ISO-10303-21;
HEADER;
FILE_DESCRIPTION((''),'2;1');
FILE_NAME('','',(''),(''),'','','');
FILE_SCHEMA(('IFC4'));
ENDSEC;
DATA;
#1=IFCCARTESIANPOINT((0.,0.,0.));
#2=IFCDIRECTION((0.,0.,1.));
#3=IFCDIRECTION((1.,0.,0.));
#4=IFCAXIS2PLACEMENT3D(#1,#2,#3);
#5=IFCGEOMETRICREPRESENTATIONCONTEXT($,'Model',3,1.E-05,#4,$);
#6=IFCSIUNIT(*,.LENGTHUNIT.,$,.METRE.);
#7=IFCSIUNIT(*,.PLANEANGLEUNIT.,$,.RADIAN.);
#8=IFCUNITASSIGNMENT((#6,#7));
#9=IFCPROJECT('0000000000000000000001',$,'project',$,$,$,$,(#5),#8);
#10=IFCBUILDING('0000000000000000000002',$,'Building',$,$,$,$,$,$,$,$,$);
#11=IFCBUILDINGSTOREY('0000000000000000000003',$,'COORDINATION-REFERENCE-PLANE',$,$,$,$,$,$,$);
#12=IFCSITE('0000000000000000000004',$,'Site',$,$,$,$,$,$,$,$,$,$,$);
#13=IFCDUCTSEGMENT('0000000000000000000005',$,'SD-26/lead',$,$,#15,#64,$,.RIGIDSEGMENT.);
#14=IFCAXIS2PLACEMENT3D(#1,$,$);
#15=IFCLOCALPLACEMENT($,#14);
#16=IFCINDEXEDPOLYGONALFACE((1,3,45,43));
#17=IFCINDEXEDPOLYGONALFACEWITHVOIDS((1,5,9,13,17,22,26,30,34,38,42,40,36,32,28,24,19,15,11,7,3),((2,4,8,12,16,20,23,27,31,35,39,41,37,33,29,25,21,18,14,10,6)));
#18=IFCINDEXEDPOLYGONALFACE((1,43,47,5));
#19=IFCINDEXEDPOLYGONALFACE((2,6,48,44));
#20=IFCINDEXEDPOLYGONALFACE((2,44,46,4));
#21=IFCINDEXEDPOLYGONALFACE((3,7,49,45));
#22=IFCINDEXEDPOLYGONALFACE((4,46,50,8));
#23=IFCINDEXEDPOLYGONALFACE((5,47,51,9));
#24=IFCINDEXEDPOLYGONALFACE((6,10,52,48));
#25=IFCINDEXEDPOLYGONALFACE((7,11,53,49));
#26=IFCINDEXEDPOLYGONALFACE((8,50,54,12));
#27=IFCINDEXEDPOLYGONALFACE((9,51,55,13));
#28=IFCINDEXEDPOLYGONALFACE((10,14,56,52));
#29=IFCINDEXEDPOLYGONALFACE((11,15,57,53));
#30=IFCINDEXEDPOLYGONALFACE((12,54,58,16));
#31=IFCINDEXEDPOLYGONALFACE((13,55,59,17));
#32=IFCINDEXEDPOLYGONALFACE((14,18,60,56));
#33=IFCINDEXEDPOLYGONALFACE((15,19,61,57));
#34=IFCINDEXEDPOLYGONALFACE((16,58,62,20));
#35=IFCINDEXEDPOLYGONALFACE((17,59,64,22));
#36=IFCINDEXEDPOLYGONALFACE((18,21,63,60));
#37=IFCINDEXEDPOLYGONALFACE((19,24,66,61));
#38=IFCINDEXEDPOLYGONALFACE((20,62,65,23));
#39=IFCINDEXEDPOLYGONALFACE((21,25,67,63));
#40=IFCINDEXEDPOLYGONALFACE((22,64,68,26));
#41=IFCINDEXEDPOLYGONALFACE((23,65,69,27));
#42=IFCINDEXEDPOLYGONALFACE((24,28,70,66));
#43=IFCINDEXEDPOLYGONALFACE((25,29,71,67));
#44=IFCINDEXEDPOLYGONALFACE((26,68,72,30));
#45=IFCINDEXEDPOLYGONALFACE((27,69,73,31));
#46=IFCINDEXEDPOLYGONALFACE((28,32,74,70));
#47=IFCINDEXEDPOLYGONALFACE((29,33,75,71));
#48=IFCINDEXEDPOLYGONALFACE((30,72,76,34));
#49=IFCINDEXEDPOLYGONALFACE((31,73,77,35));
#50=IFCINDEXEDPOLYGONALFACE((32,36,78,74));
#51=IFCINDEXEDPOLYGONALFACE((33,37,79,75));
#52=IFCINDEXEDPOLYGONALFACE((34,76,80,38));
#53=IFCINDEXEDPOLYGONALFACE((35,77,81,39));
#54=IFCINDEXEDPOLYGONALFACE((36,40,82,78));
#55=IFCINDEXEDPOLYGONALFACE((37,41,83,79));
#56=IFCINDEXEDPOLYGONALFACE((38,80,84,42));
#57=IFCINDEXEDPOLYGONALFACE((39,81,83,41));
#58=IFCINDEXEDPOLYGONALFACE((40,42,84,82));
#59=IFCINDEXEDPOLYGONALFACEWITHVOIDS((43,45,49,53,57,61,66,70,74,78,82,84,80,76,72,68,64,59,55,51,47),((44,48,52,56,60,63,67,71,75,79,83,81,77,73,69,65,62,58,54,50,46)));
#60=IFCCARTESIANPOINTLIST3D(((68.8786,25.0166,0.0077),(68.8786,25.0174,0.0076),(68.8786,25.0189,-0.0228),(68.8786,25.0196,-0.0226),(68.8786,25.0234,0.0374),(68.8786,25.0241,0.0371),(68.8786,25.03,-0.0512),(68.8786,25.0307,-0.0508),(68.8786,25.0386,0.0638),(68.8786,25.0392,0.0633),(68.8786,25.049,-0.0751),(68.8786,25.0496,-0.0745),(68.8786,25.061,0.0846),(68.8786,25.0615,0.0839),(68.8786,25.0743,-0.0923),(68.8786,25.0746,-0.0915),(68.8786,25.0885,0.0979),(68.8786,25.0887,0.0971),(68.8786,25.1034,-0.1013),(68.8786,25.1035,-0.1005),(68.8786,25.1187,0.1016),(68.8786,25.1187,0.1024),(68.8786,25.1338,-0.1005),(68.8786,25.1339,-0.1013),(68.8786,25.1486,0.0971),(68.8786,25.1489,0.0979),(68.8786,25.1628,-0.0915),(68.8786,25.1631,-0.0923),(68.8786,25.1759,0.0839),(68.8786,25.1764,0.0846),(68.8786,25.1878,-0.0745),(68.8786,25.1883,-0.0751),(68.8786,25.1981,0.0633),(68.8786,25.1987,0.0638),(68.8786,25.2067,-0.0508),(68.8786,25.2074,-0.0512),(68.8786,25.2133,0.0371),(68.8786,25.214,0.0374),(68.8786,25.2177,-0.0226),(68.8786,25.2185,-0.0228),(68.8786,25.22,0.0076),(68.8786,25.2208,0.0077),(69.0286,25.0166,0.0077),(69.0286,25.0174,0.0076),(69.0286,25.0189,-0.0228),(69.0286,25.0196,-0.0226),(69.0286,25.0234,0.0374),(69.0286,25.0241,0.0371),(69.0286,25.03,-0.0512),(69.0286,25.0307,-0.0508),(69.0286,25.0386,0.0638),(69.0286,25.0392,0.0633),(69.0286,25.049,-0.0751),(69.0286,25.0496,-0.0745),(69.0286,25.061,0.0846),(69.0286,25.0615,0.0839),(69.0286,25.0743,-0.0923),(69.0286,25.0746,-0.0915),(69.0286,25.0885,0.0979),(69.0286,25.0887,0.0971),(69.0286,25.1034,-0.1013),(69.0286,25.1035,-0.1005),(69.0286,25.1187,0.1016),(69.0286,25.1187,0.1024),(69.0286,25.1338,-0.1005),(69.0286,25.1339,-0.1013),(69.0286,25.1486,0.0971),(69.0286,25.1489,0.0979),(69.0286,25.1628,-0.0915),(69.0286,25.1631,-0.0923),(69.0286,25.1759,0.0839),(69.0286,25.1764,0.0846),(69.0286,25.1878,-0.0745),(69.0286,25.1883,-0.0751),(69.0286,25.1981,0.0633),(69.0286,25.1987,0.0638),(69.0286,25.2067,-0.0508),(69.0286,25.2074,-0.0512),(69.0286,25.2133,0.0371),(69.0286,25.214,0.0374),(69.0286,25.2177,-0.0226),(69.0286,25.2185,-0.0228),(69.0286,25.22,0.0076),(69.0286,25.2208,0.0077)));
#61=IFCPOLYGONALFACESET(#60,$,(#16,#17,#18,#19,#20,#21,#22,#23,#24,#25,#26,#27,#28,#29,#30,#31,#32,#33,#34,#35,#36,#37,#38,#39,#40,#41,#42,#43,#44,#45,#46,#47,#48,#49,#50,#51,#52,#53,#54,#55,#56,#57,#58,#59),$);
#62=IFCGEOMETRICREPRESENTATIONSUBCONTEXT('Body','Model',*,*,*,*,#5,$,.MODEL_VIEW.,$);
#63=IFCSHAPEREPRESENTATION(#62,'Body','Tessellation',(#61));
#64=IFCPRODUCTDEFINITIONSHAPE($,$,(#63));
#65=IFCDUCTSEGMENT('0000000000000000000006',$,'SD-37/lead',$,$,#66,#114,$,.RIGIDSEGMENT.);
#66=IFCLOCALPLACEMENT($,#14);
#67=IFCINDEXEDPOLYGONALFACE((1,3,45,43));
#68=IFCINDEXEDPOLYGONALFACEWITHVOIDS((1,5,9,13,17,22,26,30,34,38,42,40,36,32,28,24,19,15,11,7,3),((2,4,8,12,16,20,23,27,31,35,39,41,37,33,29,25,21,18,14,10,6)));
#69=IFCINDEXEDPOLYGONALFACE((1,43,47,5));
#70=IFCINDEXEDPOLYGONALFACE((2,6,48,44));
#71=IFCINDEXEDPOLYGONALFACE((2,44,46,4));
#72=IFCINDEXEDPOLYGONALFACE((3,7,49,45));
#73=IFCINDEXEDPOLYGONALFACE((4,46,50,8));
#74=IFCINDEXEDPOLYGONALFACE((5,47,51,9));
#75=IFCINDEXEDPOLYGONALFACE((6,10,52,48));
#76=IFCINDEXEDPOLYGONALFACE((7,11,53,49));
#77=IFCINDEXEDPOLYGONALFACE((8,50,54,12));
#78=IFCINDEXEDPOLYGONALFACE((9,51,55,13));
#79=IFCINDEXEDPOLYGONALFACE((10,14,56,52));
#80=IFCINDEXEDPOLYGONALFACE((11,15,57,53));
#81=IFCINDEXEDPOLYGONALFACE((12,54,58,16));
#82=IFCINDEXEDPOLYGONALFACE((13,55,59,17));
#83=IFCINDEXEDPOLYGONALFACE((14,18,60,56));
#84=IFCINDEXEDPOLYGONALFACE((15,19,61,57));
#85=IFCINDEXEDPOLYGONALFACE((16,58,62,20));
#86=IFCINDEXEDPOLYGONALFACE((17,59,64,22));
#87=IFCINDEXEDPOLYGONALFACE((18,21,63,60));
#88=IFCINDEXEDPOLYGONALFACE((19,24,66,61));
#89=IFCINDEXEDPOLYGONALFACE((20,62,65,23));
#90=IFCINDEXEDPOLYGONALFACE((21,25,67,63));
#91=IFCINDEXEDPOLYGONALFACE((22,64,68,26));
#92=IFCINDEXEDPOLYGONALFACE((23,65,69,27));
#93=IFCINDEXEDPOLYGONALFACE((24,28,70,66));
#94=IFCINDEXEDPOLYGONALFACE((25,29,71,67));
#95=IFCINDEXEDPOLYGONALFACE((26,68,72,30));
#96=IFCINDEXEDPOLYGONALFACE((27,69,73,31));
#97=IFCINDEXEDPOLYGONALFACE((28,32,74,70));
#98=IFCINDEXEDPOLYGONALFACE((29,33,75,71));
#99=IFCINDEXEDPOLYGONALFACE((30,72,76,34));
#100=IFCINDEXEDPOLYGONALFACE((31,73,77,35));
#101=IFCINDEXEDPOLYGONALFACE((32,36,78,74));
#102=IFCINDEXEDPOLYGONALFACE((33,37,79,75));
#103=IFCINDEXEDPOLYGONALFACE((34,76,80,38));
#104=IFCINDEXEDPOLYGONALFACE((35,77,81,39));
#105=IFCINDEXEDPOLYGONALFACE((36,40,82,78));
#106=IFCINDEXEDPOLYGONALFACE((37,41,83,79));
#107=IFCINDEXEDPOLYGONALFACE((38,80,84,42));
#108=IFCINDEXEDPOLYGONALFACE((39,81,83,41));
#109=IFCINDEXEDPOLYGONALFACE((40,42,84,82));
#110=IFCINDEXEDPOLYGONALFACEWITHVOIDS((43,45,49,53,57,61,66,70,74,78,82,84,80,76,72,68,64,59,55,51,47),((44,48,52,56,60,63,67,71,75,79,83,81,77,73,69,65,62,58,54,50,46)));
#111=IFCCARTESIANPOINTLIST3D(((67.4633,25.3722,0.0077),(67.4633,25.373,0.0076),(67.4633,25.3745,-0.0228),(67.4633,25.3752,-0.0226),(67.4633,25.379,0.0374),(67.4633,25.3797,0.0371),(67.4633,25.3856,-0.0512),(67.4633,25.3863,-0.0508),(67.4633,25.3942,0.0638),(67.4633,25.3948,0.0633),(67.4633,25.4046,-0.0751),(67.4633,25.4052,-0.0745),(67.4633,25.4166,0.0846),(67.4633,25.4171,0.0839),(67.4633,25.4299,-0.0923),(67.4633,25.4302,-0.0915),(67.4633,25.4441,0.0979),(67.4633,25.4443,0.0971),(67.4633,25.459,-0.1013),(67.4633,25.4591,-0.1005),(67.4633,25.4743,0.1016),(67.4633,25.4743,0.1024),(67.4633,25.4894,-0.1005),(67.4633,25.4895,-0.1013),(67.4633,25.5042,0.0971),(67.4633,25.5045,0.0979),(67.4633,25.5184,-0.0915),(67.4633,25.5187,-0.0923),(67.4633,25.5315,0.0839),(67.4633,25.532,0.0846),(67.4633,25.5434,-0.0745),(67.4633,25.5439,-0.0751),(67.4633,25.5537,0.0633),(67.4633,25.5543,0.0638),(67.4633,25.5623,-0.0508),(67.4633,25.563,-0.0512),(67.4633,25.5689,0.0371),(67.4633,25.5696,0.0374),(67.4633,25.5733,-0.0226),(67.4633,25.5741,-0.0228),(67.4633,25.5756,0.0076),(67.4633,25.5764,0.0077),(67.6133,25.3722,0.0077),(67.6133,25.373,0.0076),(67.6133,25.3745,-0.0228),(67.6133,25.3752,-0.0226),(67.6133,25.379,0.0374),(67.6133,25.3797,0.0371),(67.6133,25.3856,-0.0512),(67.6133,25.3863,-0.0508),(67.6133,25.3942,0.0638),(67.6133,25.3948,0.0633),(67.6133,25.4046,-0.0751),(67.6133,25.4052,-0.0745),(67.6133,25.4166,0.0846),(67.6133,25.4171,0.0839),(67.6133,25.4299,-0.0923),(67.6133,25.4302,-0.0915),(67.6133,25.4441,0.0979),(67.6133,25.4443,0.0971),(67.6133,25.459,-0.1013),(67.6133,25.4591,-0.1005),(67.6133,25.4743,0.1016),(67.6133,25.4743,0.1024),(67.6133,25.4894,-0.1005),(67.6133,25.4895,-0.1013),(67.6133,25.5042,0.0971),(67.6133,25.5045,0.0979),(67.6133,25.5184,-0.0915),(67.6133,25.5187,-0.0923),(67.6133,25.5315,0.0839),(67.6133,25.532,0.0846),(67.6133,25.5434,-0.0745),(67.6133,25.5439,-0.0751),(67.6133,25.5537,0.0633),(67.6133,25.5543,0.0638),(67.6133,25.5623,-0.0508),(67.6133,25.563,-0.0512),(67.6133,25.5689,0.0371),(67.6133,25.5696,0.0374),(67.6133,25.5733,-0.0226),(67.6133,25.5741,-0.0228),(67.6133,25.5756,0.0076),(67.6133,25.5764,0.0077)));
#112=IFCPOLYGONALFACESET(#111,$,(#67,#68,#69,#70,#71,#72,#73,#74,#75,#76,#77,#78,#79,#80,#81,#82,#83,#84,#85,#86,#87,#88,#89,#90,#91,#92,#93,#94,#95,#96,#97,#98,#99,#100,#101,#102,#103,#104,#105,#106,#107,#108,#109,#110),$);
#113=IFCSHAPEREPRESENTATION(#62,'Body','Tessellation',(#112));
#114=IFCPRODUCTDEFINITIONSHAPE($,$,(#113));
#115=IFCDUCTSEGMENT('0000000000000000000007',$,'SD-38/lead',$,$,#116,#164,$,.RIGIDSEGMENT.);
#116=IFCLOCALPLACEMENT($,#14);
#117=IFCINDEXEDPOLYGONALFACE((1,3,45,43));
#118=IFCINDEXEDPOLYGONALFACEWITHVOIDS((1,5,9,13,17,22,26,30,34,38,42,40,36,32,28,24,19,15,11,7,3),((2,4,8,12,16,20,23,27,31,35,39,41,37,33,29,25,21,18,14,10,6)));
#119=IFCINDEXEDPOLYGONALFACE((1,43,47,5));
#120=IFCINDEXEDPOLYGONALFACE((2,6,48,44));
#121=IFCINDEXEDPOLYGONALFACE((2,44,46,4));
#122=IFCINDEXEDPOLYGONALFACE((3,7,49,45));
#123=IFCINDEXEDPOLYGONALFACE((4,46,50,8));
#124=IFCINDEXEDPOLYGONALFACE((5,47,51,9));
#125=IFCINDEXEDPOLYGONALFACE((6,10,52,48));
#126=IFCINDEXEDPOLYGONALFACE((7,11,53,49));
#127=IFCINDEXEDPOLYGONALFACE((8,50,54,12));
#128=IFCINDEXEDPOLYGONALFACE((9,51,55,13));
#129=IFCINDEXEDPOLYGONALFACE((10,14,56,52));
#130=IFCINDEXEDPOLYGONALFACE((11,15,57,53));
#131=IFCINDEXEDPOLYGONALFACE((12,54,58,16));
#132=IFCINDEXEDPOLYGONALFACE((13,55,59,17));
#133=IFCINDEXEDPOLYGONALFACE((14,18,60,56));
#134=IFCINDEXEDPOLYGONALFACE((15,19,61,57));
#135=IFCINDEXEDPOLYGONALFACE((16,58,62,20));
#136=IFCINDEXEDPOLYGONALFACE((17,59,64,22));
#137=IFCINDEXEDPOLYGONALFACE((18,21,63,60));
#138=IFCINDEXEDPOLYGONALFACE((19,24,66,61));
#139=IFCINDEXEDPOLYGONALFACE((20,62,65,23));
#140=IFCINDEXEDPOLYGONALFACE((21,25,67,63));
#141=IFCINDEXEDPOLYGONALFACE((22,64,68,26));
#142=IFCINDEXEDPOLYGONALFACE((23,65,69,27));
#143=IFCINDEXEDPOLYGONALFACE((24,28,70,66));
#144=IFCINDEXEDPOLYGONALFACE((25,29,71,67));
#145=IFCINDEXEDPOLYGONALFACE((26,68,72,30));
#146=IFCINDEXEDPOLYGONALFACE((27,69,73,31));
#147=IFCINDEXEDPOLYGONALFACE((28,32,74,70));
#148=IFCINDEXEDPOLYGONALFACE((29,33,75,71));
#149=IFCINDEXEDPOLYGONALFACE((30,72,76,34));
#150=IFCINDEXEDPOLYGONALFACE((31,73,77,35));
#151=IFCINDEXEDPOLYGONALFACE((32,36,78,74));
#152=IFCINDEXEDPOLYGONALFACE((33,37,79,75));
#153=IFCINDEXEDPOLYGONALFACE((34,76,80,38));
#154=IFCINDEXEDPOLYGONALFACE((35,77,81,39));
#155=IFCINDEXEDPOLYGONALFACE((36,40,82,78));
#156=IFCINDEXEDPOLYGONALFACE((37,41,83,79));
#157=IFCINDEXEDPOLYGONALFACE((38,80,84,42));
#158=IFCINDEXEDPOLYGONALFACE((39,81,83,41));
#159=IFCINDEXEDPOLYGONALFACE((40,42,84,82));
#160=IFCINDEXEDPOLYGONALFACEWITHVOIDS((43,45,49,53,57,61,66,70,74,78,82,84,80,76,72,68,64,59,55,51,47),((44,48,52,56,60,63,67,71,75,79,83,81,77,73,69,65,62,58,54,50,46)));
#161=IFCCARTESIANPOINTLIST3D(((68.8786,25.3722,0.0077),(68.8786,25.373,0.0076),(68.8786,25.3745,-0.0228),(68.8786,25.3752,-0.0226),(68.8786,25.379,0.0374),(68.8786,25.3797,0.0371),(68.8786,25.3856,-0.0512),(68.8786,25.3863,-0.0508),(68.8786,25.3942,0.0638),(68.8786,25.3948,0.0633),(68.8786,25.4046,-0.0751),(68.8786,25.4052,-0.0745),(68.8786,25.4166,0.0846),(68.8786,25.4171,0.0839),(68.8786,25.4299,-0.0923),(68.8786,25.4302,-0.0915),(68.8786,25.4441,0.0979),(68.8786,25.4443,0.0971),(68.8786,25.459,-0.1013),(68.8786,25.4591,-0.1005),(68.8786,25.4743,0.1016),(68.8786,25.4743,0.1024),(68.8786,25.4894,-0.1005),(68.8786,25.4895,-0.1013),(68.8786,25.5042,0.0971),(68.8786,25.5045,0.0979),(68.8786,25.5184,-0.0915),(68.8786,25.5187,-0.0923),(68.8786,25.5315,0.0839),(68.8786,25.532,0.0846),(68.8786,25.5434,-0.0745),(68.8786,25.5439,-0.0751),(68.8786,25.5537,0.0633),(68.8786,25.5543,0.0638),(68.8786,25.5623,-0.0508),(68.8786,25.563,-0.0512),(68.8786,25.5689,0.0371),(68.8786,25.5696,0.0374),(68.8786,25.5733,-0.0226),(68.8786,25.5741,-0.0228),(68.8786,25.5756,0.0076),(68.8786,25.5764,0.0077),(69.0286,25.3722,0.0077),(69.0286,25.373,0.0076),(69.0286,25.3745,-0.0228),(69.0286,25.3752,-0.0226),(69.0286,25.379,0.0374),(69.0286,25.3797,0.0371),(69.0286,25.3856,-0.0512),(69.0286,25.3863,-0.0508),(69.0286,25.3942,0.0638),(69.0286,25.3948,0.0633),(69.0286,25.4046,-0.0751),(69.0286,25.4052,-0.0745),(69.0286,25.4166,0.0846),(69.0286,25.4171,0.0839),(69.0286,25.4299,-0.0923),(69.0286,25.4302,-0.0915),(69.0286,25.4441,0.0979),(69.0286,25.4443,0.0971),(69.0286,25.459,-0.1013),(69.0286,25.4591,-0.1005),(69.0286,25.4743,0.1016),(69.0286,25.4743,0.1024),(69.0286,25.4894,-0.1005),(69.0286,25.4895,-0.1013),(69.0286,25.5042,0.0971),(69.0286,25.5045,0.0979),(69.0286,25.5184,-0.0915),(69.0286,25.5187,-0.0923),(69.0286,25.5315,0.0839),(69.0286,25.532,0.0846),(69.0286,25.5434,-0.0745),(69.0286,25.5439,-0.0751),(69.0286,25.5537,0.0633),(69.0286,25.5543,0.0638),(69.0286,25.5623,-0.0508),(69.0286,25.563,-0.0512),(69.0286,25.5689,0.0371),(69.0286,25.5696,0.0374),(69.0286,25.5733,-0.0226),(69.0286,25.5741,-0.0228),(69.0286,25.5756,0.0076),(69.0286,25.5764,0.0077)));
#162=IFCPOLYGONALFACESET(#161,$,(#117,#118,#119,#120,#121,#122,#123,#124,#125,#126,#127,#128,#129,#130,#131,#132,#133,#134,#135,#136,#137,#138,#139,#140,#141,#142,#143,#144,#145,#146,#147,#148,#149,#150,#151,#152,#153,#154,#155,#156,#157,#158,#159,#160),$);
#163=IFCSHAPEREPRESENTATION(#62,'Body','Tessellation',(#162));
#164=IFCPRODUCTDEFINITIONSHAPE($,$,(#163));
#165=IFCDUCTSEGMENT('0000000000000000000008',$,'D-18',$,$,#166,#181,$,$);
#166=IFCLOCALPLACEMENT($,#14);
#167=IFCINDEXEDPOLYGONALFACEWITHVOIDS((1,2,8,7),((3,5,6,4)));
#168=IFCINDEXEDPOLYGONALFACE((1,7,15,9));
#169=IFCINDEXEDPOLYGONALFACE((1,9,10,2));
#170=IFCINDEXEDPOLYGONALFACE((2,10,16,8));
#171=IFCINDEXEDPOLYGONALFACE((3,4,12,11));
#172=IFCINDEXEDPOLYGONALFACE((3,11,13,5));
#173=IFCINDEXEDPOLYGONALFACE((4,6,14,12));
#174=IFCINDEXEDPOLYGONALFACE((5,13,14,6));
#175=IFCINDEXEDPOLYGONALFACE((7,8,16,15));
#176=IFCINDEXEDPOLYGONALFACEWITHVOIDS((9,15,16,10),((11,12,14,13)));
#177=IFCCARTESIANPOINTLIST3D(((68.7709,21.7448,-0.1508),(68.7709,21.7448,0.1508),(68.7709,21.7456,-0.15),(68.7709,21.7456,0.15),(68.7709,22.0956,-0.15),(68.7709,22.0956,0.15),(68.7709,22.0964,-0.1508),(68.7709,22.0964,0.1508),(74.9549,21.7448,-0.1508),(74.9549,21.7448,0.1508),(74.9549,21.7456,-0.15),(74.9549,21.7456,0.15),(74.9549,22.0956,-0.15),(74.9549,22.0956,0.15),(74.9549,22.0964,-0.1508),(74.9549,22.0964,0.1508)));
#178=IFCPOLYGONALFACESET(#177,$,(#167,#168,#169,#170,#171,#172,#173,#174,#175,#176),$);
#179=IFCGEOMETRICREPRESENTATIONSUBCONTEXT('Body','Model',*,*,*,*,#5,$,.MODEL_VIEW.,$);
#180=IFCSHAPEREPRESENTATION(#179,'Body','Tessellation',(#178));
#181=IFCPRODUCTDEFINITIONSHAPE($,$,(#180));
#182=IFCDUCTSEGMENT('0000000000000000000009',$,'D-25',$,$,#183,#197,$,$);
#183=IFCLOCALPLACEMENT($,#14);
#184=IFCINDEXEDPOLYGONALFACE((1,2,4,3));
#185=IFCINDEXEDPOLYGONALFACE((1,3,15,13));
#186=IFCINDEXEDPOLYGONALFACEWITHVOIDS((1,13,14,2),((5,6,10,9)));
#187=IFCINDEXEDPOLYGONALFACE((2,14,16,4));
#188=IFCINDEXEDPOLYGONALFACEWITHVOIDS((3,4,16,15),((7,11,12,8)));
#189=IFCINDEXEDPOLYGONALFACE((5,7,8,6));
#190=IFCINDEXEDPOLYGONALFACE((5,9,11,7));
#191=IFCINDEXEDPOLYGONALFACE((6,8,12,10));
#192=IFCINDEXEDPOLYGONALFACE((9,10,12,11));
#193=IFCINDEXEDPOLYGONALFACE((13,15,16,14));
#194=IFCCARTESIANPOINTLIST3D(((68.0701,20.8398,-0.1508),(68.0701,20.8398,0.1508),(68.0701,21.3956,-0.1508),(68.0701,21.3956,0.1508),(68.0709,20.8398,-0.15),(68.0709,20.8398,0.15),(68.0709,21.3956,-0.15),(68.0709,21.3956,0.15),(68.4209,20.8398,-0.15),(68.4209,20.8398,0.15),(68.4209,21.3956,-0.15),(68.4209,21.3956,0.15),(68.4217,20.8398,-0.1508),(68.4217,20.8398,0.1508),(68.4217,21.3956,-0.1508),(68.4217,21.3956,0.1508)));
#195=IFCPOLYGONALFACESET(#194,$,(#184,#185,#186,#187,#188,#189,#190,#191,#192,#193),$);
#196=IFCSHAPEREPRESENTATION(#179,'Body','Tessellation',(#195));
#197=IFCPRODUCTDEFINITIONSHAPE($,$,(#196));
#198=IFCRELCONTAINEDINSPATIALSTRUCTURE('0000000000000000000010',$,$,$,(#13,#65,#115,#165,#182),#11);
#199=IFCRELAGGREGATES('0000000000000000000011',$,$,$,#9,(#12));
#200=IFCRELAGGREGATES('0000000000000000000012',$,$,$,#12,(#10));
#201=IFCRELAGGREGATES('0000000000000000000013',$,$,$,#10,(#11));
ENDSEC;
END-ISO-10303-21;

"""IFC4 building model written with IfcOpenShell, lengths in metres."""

from ifc_helpers import new_model, si_unit, frame, origin, origin_with_axes, place, context, subcontext, project, spatial, hollow_rectangle, hollow_circle, extrude, element, save


model = new_model("IFC4")

# Units and contexts
model_context = context("Model", 3, precision=1e-05, world=origin_with_axes())
body_context_1 = subcontext(model_context, "Body", "Model", "MODEL_VIEW")
body_context_2 = subcontext(model_context, "Body", "Model", "MODEL_VIEW")
ifc_project = project(units=[si_unit("LENGTHUNIT", "METRE"), si_unit("PLANEANGLEUNIT", "RADIAN")], contexts=[model_context])

# Site, building, storey
site = spatial("IfcSite", under=ifc_project, Name="Site")
building = spatial("IfcBuilding", under=site, Name="Building")
storey = spatial("IfcBuildingStorey", under=building, Name="COORDINATION-REFERENCE-PLANE")

# Duct segments
for number, where, z_axis, x_axis, name in (
    (1, (68.8786, 25.1187, 0.0), (1.0, 0.0, 0.0), (0.0, 0.0, 1.0), "SD-26/lead"),
    (2, (67.6133, 25.4743, 0.0), (-1.0, 0.0, 0.0), (0.0, 0.0, 1.0), "SD-37/lead"),
    (3, (68.8786, 25.4743, 0.0), (1.0, 0.0, 0.0), (0.0, 0.0, 1.0), "SD-38/lead"),
):
    element("IfcDuctSegment", number, at=place(None, frame(where, z_axis=z_axis, x_axis=x_axis)), inside=storey, Name=name, PredefinedType="RIGIDSEGMENT", context=body_context_1, shape_type="SweptSolid", body=[
        extrude(hollow_circle(Radius=0.1024, WallThickness=0.0008), origin_with_axes(), (0.0, 0.0, 1.0), 0.15),
    ])

# Duct segments
duct_segment_1_placement = place(None, frame((68.7709, 21.9206, 0.0), z_axis=(1.0, 0.0, 0.0), x_axis=(0.0, 1.0, 0.0)))
element("IfcDuctSegment", 4, at=duct_segment_1_placement, inside=storey, Name="D-18", context=body_context_2, shape_type="SweptSolid", body=[
    extrude(hollow_rectangle(XDim=0.3516, YDim=0.3016, WallThickness=0.0008), origin(), (0.0, 0.0, 1.0), 6.1839),
])
duct_segment_2_placement = place(None, frame((68.2459, 20.8398, 0.0), z_axis=(0.0, 1.0, 0.0), x_axis=(1.0, 0.0, 0.0)))
element("IfcDuctSegment", 5, at=duct_segment_2_placement, inside=storey, Name="D-25", context=body_context_2, shape_type="SweptSolid", body=[
    extrude(hollow_rectangle(XDim=0.3516, YDim=0.3016, WallThickness=0.0008), origin(), (0.0, 0.0, 1.0), 0.5558),
])

save(model, "model.ifc")
